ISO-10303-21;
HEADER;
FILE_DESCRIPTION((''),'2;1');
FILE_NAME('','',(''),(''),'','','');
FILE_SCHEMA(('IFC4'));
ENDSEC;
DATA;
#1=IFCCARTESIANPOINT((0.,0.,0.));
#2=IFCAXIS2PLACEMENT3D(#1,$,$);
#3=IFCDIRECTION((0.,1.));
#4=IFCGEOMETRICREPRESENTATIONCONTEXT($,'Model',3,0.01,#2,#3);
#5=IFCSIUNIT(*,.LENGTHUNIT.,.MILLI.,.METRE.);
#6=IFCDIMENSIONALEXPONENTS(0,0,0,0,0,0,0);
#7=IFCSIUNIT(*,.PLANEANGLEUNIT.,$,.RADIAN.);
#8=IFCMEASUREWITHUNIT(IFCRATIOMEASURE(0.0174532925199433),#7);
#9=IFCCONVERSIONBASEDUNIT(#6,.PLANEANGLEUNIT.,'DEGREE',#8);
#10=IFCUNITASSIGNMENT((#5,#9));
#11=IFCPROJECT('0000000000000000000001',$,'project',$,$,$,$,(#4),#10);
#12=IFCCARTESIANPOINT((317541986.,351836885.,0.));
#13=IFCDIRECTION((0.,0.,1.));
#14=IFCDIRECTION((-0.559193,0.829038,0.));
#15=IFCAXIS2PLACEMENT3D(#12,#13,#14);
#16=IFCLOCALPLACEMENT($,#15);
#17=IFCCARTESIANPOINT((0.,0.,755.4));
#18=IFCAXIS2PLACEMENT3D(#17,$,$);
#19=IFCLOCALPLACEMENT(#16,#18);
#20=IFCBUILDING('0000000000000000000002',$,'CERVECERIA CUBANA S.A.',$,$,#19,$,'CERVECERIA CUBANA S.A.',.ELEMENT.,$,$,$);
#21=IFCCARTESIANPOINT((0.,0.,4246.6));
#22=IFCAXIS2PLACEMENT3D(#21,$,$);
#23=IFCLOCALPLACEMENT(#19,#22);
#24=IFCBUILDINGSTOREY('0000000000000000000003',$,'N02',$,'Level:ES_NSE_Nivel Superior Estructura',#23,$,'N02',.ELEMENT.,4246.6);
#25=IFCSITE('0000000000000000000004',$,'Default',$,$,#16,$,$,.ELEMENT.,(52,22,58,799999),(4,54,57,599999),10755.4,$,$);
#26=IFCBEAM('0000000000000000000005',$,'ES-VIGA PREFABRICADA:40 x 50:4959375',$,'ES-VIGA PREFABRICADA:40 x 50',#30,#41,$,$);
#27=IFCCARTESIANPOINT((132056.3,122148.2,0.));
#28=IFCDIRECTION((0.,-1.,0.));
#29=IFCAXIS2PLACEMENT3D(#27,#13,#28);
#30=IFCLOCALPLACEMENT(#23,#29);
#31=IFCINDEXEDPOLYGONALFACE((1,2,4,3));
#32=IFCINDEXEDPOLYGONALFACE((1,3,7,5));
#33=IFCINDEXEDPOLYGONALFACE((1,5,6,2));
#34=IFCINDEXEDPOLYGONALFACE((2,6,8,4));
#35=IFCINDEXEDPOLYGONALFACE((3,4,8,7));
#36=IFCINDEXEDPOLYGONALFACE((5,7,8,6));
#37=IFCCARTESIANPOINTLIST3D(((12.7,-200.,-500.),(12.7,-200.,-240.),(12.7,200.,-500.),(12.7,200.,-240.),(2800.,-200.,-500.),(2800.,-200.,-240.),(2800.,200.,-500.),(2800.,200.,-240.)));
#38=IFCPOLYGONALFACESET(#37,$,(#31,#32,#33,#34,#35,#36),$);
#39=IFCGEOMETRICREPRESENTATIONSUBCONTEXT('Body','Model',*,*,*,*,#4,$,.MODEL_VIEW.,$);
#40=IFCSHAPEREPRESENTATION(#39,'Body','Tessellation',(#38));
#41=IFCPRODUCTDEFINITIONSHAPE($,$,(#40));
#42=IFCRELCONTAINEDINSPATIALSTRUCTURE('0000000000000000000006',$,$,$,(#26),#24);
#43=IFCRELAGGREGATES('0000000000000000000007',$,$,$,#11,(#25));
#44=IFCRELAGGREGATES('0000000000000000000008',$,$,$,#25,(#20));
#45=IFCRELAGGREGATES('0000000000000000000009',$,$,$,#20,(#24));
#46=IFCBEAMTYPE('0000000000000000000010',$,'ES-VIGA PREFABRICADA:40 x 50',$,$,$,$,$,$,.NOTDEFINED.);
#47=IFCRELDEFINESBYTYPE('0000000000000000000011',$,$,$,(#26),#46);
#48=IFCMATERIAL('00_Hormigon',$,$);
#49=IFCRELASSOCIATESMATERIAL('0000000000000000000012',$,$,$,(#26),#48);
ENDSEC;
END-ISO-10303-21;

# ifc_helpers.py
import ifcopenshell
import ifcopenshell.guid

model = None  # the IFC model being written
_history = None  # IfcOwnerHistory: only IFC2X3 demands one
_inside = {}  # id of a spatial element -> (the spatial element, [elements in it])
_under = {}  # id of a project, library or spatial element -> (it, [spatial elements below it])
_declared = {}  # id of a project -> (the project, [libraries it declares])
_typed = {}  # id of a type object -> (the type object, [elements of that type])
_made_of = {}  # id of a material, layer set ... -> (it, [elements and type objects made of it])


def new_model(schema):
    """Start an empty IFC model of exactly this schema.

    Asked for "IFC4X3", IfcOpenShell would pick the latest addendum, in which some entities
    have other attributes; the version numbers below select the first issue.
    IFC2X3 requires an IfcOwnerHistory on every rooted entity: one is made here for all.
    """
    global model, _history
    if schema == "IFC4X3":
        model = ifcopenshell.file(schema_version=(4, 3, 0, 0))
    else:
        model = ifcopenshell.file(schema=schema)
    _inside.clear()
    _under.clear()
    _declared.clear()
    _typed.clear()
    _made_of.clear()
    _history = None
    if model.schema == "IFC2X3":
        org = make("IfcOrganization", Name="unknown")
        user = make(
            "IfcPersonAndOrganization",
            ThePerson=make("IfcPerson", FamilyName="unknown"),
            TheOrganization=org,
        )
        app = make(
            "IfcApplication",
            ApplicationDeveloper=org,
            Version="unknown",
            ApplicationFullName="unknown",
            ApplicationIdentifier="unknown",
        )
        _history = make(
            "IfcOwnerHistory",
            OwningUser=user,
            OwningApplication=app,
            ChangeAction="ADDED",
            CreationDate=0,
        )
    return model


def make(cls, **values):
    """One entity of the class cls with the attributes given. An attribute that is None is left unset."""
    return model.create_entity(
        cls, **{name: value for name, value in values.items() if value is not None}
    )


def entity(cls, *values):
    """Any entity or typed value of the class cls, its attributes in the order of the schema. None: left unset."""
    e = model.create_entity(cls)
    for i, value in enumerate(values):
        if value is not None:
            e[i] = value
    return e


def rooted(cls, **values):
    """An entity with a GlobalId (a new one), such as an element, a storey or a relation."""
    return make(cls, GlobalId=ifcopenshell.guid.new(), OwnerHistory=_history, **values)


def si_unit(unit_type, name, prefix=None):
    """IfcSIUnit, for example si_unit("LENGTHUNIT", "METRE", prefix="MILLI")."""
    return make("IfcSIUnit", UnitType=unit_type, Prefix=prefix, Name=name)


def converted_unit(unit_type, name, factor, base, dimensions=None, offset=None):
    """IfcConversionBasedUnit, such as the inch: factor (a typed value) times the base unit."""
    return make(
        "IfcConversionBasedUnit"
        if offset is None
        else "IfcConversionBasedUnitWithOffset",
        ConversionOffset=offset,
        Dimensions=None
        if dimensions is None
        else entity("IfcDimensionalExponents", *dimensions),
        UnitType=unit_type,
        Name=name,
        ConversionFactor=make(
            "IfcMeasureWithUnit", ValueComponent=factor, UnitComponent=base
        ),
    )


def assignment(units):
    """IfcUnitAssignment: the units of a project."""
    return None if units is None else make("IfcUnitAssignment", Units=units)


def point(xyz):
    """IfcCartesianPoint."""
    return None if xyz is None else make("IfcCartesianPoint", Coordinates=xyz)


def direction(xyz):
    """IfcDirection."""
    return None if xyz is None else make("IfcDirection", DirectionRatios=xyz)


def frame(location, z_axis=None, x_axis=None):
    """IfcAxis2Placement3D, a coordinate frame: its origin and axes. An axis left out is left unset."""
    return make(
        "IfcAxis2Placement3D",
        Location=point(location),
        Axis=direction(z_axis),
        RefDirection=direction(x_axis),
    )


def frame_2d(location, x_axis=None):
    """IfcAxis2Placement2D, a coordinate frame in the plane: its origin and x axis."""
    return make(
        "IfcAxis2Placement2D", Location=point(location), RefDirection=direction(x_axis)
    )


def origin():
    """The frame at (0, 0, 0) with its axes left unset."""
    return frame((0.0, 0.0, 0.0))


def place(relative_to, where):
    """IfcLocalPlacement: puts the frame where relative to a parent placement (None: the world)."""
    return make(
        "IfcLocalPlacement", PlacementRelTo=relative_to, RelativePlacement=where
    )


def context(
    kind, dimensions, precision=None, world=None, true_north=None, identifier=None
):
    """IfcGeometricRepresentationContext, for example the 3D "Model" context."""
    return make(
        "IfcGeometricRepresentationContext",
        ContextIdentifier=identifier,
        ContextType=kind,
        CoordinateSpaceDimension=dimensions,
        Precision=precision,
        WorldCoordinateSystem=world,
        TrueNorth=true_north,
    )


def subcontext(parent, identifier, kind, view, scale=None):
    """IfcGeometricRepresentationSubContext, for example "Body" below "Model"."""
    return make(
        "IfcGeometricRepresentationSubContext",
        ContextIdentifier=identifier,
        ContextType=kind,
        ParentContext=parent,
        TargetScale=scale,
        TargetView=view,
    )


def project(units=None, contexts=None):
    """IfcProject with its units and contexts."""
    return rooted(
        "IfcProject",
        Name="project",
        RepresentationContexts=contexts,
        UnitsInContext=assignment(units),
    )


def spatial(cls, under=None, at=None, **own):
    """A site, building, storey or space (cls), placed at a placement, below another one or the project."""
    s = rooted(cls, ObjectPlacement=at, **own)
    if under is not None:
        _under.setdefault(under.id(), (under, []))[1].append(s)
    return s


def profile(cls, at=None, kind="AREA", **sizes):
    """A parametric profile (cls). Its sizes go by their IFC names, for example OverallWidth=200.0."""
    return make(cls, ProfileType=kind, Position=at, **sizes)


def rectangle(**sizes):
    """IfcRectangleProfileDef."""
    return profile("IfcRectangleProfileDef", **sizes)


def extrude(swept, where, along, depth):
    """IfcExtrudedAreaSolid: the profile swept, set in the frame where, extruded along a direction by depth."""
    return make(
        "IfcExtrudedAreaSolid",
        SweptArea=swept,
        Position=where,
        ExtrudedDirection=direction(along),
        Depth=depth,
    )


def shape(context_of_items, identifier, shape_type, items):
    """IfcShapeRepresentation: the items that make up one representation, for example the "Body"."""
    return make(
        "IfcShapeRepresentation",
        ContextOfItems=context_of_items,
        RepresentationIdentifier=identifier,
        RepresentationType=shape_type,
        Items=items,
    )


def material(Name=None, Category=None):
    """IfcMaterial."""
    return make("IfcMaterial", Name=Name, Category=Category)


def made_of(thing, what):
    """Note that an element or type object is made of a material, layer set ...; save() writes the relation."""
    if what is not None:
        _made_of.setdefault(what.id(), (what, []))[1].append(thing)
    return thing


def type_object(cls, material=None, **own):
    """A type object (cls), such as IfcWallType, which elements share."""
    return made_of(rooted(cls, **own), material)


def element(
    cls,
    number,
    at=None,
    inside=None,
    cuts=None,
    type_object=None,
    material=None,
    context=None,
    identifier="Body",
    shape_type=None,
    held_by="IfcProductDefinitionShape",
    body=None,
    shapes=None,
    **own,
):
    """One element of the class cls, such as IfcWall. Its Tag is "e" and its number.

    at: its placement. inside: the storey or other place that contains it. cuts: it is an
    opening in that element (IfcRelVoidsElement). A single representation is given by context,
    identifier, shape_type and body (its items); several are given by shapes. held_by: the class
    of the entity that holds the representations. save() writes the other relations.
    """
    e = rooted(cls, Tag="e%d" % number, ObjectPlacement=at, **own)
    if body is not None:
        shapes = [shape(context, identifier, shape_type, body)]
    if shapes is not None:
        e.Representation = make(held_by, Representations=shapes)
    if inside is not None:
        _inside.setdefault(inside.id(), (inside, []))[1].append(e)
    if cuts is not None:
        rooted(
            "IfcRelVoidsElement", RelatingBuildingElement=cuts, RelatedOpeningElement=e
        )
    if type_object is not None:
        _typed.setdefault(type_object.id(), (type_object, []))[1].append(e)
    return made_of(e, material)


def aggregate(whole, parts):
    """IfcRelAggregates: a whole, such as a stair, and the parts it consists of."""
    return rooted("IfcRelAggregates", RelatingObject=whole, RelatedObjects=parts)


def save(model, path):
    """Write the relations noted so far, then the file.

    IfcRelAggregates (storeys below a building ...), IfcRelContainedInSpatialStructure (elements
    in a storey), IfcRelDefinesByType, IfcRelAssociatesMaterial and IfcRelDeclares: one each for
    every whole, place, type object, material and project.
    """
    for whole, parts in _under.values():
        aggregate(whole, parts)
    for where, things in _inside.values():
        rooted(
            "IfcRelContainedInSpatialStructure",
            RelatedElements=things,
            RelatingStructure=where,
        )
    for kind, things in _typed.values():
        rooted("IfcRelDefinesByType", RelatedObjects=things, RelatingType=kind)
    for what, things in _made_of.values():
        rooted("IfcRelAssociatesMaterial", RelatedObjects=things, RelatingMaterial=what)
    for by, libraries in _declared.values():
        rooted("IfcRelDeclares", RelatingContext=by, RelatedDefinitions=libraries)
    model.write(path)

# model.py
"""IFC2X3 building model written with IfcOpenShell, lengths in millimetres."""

from ifc_helpers import new_model, entity, si_unit, converted_unit, direction, frame, frame_2d, origin, place, context, subcontext, project, spatial, rectangle, extrude, material, type_object, element, save


model = new_model("IFC2X3")

# Units and contexts
model_context = context("Model", 3, precision=0.01, world=origin(), true_north=direction((0.0, 1.0)))
body_context = subcontext(model_context, "Body", "Model", "MODEL_VIEW")
ifc_project = project(units=[si_unit("LENGTHUNIT", "METRE", prefix="MILLI"), converted_unit("PLANEANGLEUNIT", "DEGREE", entity("IfcRatioMeasure", 0.0174532925199433), si_unit("PLANEANGLEUNIT", "RADIAN"), dimensions=[0, 0, 0, 0, 0, 0, 0])], contexts=[model_context])

# Site, building, storey
site_placement = place(None, frame((317541986.0, 351836885.0, 0.0), z_axis=(0.0, 0.0, 1.0), x_axis=(-0.559193, 0.829038, 0.0)))
site = spatial("IfcSite", under=ifc_project, at=site_placement, Name="Default", CompositionType="ELEMENT", RefLatitude=(52, 22, 58, 799999), RefLongitude=(4, 54, 57, 599999), RefElevation=10755.4)
building_placement = place(site_placement, frame((0.0, 0.0, 755.4)))
building = spatial("IfcBuilding", under=site, at=building_placement, Name="CERVECERIA CUBANA S.A.", LongName="CERVECERIA CUBANA S.A.", CompositionType="ELEMENT")
storey_placement = place(building_placement, frame((0.0, 0.0, 4246.6)))
storey = spatial("IfcBuildingStorey", under=building, at=storey_placement, Name="N02", ObjectType="Level:ES_NSE_Nivel Superior Estructura", LongName="N02", CompositionType="ELEMENT", Elevation=4246.6)

# Beam
ifc_material_1 = material(Name="00_Hormigon")
beam_type = type_object("IfcBeamType", Name="ES-VIGA PREFABRICADA:40 x 50", PredefinedType="NOTDEFINED")
beam_1_placement = place(storey_placement, frame((132056.3, 122148.2, 0.0), z_axis=(0.0, 0.0, 1.0), x_axis=(0.0, -1.0, 0.0)))
element("IfcBeam", 1, at=beam_1_placement, inside=storey, type_object=beam_type, material=ifc_material_1, Name="ES-VIGA PREFABRICADA:40 x 50:4959375", ObjectType="ES-VIGA PREFABRICADA:40 x 50", context=body_context, shape_type="SweptSolid", body=[
    extrude(rectangle(XDim=260.0, YDim=400.0, at=frame_2d((0.0, 0.0), x_axis=(1.0, 0.0))), frame((12.7, 0.0, -370.0), z_axis=(1.0, 0.0, 0.0), x_axis=(0.0, 0.0, -1.0)), (0.0, 0.0, 1.0), 2787.3),
])

save(model, "model.ifc")
